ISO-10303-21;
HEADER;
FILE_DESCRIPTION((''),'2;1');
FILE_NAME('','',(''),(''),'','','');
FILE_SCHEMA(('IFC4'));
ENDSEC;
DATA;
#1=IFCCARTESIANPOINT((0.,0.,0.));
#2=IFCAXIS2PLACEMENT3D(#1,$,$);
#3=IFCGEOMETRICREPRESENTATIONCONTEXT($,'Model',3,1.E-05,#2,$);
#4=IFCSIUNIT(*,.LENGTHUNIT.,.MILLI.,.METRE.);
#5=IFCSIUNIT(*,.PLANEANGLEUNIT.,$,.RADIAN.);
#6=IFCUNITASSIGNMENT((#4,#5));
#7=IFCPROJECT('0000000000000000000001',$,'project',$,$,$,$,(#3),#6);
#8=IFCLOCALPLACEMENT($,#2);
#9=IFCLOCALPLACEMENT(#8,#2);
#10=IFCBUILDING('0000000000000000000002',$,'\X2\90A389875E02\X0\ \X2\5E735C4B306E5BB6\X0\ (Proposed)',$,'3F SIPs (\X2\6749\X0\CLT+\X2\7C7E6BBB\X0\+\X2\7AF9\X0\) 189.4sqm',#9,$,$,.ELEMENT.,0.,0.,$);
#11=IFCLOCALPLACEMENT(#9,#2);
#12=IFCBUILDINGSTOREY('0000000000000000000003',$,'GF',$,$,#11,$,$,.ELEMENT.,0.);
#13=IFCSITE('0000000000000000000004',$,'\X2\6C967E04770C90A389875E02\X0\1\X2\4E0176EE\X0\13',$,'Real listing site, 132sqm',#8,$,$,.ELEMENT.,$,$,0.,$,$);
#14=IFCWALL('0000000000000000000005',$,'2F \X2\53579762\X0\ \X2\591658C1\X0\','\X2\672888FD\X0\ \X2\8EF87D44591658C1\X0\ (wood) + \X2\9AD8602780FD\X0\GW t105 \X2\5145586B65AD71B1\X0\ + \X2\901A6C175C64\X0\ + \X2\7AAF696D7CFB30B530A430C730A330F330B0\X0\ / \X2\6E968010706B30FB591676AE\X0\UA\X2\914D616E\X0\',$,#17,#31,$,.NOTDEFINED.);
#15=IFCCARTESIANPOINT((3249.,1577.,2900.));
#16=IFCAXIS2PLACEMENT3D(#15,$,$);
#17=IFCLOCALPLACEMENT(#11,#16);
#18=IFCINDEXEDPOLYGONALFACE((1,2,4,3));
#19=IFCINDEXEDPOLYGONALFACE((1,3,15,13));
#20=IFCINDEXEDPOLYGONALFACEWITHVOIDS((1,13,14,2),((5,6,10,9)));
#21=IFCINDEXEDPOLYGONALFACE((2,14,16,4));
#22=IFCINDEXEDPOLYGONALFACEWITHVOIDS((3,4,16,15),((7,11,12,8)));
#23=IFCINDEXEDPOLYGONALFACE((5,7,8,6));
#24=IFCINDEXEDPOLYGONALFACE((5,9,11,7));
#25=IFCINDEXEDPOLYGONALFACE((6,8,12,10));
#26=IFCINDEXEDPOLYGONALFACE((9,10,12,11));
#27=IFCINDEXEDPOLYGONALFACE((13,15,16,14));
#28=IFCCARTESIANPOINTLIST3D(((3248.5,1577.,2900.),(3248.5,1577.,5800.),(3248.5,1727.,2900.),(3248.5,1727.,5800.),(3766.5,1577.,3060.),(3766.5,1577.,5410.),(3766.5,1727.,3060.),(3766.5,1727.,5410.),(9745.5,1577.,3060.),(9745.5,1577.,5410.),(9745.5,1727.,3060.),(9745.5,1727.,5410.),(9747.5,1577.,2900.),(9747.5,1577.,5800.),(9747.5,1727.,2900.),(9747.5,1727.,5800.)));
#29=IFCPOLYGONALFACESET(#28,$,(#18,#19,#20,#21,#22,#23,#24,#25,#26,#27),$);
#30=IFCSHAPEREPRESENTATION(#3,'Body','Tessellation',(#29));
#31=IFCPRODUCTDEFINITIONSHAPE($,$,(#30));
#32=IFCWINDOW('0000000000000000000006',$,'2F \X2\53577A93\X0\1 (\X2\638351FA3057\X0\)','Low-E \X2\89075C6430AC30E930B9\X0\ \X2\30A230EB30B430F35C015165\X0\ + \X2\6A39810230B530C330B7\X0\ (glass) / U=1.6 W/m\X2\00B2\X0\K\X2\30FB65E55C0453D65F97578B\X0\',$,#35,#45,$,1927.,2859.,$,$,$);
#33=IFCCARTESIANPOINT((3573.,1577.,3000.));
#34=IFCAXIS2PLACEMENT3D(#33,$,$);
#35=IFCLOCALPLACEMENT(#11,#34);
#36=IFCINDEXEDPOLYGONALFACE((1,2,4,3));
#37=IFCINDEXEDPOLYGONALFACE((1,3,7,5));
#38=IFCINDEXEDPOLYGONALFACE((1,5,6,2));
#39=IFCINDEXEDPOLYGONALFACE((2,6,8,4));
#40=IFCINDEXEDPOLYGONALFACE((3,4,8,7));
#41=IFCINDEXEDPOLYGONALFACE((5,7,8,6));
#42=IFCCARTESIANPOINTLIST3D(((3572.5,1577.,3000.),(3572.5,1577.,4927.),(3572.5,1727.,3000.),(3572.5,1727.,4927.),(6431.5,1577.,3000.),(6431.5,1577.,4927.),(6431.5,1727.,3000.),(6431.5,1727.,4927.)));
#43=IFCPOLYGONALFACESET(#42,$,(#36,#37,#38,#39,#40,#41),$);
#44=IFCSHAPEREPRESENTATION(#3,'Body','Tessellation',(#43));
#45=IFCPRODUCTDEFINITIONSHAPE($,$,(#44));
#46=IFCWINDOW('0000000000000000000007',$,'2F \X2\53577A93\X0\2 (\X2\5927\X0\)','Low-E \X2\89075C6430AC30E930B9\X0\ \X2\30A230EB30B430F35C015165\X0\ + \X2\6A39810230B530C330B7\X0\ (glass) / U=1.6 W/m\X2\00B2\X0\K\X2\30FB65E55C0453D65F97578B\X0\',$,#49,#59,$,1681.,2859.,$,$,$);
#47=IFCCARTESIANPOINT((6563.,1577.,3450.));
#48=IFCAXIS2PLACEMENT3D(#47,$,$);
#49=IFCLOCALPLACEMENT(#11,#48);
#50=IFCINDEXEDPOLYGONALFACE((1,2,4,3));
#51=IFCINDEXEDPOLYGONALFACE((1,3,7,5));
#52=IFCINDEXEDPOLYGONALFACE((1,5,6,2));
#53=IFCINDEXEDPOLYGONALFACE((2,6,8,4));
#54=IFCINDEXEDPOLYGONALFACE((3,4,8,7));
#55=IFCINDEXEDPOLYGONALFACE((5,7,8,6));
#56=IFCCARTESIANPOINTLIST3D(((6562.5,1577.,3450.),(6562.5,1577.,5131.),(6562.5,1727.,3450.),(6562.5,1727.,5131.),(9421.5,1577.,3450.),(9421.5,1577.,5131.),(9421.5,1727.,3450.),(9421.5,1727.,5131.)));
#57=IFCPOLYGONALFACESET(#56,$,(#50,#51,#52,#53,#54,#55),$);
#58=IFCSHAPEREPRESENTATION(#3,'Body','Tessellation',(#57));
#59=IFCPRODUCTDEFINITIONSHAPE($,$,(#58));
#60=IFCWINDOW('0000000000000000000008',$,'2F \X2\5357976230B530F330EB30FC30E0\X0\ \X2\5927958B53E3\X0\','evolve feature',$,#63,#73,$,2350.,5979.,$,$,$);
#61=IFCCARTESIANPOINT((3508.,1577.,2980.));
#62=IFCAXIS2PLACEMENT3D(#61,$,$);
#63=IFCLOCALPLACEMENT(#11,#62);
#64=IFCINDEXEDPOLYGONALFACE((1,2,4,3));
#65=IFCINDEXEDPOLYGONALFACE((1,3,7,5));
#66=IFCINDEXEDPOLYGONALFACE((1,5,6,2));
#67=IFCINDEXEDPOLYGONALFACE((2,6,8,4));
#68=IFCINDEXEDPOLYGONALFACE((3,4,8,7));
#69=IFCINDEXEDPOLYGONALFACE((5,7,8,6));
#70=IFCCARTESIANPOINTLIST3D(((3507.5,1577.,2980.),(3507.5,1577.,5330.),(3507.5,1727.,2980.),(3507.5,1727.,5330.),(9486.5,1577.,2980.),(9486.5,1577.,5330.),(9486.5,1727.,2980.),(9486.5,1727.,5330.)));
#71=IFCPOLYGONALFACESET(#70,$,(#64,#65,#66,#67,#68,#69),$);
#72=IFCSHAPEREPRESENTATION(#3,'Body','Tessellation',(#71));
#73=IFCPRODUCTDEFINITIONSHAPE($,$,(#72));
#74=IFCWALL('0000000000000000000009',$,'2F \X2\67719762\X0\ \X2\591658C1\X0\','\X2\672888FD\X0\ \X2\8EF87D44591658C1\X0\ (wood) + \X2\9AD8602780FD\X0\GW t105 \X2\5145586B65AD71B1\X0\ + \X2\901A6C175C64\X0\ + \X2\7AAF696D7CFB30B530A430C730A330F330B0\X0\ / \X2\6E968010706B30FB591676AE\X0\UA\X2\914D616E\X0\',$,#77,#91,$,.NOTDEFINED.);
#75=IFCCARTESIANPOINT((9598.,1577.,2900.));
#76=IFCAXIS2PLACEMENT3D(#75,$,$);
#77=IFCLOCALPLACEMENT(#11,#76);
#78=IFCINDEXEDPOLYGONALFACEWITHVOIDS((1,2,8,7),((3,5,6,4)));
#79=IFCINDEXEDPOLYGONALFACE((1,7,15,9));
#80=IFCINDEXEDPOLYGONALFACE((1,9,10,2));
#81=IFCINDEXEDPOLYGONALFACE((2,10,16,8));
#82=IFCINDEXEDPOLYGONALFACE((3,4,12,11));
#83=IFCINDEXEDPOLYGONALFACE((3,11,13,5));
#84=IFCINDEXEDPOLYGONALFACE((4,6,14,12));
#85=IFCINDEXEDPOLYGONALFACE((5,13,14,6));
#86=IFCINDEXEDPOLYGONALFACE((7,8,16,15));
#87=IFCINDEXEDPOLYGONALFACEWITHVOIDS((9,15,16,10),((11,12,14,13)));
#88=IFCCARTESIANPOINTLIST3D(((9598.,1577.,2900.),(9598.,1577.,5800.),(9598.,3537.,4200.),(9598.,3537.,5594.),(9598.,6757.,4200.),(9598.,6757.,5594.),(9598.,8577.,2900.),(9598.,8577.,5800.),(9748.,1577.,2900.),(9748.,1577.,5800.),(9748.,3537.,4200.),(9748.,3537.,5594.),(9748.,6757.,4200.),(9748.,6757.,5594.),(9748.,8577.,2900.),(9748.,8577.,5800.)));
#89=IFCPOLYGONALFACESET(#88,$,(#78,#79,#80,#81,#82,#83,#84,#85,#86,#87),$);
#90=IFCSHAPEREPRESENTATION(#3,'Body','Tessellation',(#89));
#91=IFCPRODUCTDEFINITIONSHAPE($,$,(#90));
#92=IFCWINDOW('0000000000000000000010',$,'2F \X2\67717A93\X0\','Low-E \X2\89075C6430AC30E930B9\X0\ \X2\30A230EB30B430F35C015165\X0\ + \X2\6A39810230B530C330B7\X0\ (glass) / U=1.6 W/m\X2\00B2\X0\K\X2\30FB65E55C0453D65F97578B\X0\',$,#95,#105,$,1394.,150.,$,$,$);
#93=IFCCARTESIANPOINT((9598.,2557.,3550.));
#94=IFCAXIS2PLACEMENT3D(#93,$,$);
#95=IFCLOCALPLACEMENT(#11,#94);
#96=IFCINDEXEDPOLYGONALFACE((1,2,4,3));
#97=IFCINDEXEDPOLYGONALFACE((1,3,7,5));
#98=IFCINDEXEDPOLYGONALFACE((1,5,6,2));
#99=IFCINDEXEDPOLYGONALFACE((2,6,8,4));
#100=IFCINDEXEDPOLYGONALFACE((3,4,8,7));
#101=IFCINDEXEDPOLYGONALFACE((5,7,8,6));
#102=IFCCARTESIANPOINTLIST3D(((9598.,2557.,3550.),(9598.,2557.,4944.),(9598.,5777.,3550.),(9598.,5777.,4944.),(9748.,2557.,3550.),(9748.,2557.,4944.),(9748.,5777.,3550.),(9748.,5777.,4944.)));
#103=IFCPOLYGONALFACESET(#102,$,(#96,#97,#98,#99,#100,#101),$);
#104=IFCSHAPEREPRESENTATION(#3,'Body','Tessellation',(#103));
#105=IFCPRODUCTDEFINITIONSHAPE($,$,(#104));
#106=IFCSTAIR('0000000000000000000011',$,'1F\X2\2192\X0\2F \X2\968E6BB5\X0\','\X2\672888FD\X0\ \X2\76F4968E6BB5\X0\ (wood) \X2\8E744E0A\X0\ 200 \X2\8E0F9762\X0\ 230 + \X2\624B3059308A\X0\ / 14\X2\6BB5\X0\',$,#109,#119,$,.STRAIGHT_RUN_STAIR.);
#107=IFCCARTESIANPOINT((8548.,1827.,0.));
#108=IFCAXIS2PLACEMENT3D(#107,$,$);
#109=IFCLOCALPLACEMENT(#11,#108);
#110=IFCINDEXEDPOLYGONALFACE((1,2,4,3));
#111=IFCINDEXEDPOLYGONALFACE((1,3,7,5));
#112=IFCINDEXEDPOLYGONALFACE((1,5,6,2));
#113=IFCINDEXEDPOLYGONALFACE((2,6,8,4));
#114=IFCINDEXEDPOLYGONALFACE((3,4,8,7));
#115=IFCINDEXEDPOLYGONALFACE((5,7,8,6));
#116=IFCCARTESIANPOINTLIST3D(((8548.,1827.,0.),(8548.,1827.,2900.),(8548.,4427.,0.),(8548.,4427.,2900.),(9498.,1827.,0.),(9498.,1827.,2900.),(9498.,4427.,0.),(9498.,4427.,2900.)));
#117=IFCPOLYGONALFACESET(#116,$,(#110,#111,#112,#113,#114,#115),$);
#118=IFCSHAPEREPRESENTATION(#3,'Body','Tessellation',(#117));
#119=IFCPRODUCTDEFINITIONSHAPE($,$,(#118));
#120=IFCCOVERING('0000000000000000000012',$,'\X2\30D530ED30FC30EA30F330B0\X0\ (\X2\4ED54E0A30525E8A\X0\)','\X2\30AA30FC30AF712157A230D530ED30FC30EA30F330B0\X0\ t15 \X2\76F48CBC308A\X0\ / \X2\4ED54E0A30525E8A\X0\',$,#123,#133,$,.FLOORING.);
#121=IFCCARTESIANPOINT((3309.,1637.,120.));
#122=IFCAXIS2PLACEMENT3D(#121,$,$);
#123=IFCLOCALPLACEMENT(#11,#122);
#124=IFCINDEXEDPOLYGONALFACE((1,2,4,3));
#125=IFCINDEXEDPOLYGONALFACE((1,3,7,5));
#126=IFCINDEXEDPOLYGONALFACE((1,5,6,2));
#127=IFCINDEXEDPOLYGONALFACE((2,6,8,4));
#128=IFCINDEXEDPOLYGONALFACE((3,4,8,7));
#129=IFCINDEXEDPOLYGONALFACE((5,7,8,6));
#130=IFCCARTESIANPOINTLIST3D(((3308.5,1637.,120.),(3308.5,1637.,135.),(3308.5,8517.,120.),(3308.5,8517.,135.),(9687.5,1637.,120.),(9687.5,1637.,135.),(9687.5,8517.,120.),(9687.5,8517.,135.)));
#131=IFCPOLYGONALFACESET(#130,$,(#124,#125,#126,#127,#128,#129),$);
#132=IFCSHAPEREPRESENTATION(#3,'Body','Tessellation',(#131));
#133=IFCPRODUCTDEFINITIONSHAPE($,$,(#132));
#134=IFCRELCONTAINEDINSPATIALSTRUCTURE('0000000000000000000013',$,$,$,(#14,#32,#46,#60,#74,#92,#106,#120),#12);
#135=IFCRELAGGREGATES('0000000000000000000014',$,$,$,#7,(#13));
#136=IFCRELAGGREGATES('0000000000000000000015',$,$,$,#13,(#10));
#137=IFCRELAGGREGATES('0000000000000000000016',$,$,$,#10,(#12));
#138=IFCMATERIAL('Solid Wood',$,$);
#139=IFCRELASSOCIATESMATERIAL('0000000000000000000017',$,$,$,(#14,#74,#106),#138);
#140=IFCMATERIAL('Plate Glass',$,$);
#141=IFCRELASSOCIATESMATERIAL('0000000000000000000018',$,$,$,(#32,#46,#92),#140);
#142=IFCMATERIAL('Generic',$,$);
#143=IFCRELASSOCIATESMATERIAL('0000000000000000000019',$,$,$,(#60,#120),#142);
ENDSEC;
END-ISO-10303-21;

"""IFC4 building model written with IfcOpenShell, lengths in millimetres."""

from ifc_helpers import new_model, si_unit, frame, frame_2d, origin, place, context, project, spatial, rectangle, extrude, material, element, fill, save


model = new_model("IFC4")

# Units and contexts
model_context = context("Model", 3, precision=1e-05, world=origin())
ifc_project = project(units=[si_unit("LENGTHUNIT", "METRE", prefix="MILLI"), si_unit("PLANEANGLEUNIT", "RADIAN")], contexts=[model_context])

# Site, building, storey
site_placement = place(None, origin())
site = spatial("IfcSite", under=ifc_project, at=site_placement, Name="沖縄県那覇市1丁目13", ObjectType="Real listing site, 132sqm", CompositionType="ELEMENT", RefElevation=0.0)
building_placement = place(site_placement, origin())
building = spatial("IfcBuilding", under=site, at=building_placement, Name="那覇市 平屋の家 (Proposed)", ObjectType="3F SIPs (杉CLT+籾殻+竹) 189.4sqm", CompositionType="ELEMENT", ElevationOfRefHeight=0.0, ElevationOfTerrain=0.0)
storey_placement = place(building_placement, origin())
storey = spatial("IfcBuildingStorey", under=building, at=storey_placement, Name="GF", CompositionType="ELEMENT", Elevation=0.0)

# Shared definitions
ifc_material_1 = material(Name="Solid Wood")

# Shared definitions
ifc_material_2 = material(Name="Plate Glass")
ifc_material_3 = material(Name="Generic")

# Wall, openings, windows
wall_1_placement = place(storey_placement, frame((3249.0, 1577.0, 2900.0)))
wall_1 = element("IfcWall", 1, at=wall_1_placement, inside=storey, material=ifc_material_1, Name="2F 南面 外壁", Description="木製 軸組外壁 (wood) + 高性能GW t105 充填断熱 + 通気層 + 窯業系サイディング / 準耐火・外皮UA配慮", PredefinedType="NOTDEFINED", context=model_context, shape_type="SweptSolid", body=[
    extrude(rectangle(XDim=6499.0, YDim=150.0, at=frame_2d((3249.0, 75.0))), frame((3249.0, 1577.0, 2900.0)), (0.0, 0.0, 1.0), 2900.0),
])
opening_1_placement = place(storey_placement, frame((3573.0, 1577.0, 3000.0)))
opening_1 = element("IfcOpeningElement", 2, at=opening_1_placement, cuts=wall_1, PredefinedType="NOTDEFINED", context=model_context, shape_type="SweptSolid", body=[
    extrude(rectangle(XDim=2859.0, YDim=150.0, at=frame_2d((1429.0, 75.0))), frame((3573.0, 1577.0, 3000.0)), (0.0, 0.0, 1.0), 1927.0),
])
opening_2_placement = place(storey_placement, frame((6563.0, 1577.0, 3450.0)))
opening_2 = element("IfcOpeningElement", 3, at=opening_2_placement, cuts=wall_1, PredefinedType="NOTDEFINED", context=model_context, shape_type="SweptSolid", body=[
    extrude(rectangle(XDim=2859.0, YDim=150.0, at=frame_2d((1429.0, 75.0))), frame((6563.0, 1577.0, 3450.0)), (0.0, 0.0, 1.0), 1681.0),
])
opening_3_placement = place(storey_placement, frame((3508.0, 1577.0, 2980.0)))
opening_3 = element("IfcOpeningElement", 4, at=opening_3_placement, cuts=wall_1, PredefinedType="NOTDEFINED", context=model_context, shape_type="SweptSolid", body=[
    extrude(rectangle(XDim=5979.0, YDim=150.0, at=frame_2d((2989.0, 75.0))), frame((3508.0, 1577.0, 2980.0)), (0.0, 0.0, 1.0), 2350.0),
])
window_1_placement = place(storey_placement, frame((3573.0, 1577.0, 3000.0)))
window_1 = element("IfcWindow", 5, at=window_1_placement, inside=storey, material=ifc_material_2, Name="2F 南窓1 (掃出し)", Description="Low-E 複層ガラス アルゴン封入 + 樹脂サッシ (glass) / U=1.6 W/m²K・日射取得型", OverallHeight=1927.0, OverallWidth=2859.0, context=model_context, shape_type="SweptSolid", body=[
    extrude(rectangle(XDim=2859.0, YDim=150.0, at=frame_2d((1429.0, 75.0))), frame((3573.0, 1577.0, 3000.0)), (0.0, 0.0, 1.0), 1927.0),
])
fill(opening_1, window_1)
window_2_placement = place(storey_placement, frame((6563.0, 1577.0, 3450.0)))
window_2 = element("IfcWindow", 6, at=window_2_placement, inside=storey, material=ifc_material_2, Name="2F 南窓2 (大)", Description="Low-E 複層ガラス アルゴン封入 + 樹脂サッシ (glass) / U=1.6 W/m²K・日射取得型", OverallHeight=1681.0, OverallWidth=2859.0, context=model_context, shape_type="SweptSolid", body=[
    extrude(rectangle(XDim=2859.0, YDim=150.0, at=frame_2d((1429.0, 75.0))), frame((6563.0, 1577.0, 3450.0)), (0.0, 0.0, 1.0), 1681.0),
])
fill(opening_2, window_2)
window_3_placement = place(storey_placement, frame((3508.0, 1577.0, 2980.0)))
window_3 = element("IfcWindow", 7, at=window_3_placement, inside=storey, material=ifc_material_3, Name="2F 南面サンルーム 大開口", Description="evolve feature", OverallHeight=2350.0, OverallWidth=5979.0, context=model_context, shape_type="SweptSolid", body=[
    extrude(rectangle(XDim=5979.0, YDim=150.0, at=frame_2d((2989.0, 75.0))), frame((3508.0, 1577.0, 2980.0)), (0.0, 0.0, 1.0), 2350.0),
])
fill(opening_3, window_3)

# Wall, opening, window
wall_2_placement = place(storey_placement, frame((9598.0, 1577.0, 2900.0)))
wall_2 = element("IfcWall", 8, at=wall_2_placement, inside=storey, material=ifc_material_1, Name="2F 東面 外壁", Description="木製 軸組外壁 (wood) + 高性能GW t105 充填断熱 + 通気層 + 窯業系サイディング / 準耐火・外皮UA配慮", PredefinedType="NOTDEFINED", context=model_context, shape_type="SweptSolid", body=[
    extrude(rectangle(XDim=150.0, YDim=7000.0, at=frame_2d((75.0, 3500.0))), frame((9598.0, 1577.0, 2900.0)), (0.0, 0.0, 1.0), 2900.0),
])
opening_4_placement = place(storey_placement, frame((9598.0, 2557.0, 3550.0)))
opening_4 = element("IfcOpeningElement", 9, at=opening_4_placement, cuts=wall_2, PredefinedType="NOTDEFINED", context=model_context, shape_type="SweptSolid", body=[
    extrude(rectangle(XDim=150.0, YDim=3220.0, at=frame_2d((75.0, 1610.0))), frame((9598.0, 2557.0, 3550.0)), (0.0, 0.0, 1.0), 1394.0),
])
window_4_placement = place(storey_placement, frame((9598.0, 2557.0, 3550.0)))
window_4 = element("IfcWindow", 10, at=window_4_placement, inside=storey, material=ifc_material_2, Name="2F 東窓", Description="Low-E 複層ガラス アルゴン封入 + 樹脂サッシ (glass) / U=1.6 W/m²K・日射取得型", OverallHeight=1394.0, OverallWidth=150.0, context=model_context, shape_type="SweptSolid", body=[
    extrude(rectangle(XDim=150.0, YDim=3220.0, at=frame_2d((75.0, 1610.0))), frame((9598.0, 2557.0, 3550.0)), (0.0, 0.0, 1.0), 1394.0),
])
fill(opening_4, window_4)

# Stair
stair_placement = place(storey_placement, frame((8548.0, 1827.0, 0.0)))
element("IfcStair", 11, at=stair_placement, inside=storey, material=ifc_material_1, Name="1F→2F 階段", Description="木製 直階段 (wood) 蹴上 200 踏面 230 + 手すり / 14段", PredefinedType="STRAIGHT_RUN_STAIR", context=model_context, shape_type="SweptSolid", body=[
    extrude(rectangle(XDim=950.0, YDim=2600.0, at=frame_2d((475.0, 1300.0))), frame((8548.0, 1827.0, 0.0)), (0.0, 0.0, 1.0), 2900.0),
])

# Covering
covering_placement = place(storey_placement, frame((3309.0, 1637.0, 120.0)))
element("IfcCovering", 12, at=covering_placement, inside=storey, material=ifc_material_3, Name="フローリング (仕上げ床)", Description="オーク無垢フローリング t15 直貼り / 仕上げ床", PredefinedType="FLOORING", context=model_context, shape_type="SweptSolid", body=[
    extrude(rectangle(XDim=6379.0, YDim=6880.0, at=frame_2d((3189.0, 3440.0))), frame((3309.0, 1637.0, 120.0)), (0.0, 0.0, 1.0), 15.0),
])

save(model, "model.ifc")
